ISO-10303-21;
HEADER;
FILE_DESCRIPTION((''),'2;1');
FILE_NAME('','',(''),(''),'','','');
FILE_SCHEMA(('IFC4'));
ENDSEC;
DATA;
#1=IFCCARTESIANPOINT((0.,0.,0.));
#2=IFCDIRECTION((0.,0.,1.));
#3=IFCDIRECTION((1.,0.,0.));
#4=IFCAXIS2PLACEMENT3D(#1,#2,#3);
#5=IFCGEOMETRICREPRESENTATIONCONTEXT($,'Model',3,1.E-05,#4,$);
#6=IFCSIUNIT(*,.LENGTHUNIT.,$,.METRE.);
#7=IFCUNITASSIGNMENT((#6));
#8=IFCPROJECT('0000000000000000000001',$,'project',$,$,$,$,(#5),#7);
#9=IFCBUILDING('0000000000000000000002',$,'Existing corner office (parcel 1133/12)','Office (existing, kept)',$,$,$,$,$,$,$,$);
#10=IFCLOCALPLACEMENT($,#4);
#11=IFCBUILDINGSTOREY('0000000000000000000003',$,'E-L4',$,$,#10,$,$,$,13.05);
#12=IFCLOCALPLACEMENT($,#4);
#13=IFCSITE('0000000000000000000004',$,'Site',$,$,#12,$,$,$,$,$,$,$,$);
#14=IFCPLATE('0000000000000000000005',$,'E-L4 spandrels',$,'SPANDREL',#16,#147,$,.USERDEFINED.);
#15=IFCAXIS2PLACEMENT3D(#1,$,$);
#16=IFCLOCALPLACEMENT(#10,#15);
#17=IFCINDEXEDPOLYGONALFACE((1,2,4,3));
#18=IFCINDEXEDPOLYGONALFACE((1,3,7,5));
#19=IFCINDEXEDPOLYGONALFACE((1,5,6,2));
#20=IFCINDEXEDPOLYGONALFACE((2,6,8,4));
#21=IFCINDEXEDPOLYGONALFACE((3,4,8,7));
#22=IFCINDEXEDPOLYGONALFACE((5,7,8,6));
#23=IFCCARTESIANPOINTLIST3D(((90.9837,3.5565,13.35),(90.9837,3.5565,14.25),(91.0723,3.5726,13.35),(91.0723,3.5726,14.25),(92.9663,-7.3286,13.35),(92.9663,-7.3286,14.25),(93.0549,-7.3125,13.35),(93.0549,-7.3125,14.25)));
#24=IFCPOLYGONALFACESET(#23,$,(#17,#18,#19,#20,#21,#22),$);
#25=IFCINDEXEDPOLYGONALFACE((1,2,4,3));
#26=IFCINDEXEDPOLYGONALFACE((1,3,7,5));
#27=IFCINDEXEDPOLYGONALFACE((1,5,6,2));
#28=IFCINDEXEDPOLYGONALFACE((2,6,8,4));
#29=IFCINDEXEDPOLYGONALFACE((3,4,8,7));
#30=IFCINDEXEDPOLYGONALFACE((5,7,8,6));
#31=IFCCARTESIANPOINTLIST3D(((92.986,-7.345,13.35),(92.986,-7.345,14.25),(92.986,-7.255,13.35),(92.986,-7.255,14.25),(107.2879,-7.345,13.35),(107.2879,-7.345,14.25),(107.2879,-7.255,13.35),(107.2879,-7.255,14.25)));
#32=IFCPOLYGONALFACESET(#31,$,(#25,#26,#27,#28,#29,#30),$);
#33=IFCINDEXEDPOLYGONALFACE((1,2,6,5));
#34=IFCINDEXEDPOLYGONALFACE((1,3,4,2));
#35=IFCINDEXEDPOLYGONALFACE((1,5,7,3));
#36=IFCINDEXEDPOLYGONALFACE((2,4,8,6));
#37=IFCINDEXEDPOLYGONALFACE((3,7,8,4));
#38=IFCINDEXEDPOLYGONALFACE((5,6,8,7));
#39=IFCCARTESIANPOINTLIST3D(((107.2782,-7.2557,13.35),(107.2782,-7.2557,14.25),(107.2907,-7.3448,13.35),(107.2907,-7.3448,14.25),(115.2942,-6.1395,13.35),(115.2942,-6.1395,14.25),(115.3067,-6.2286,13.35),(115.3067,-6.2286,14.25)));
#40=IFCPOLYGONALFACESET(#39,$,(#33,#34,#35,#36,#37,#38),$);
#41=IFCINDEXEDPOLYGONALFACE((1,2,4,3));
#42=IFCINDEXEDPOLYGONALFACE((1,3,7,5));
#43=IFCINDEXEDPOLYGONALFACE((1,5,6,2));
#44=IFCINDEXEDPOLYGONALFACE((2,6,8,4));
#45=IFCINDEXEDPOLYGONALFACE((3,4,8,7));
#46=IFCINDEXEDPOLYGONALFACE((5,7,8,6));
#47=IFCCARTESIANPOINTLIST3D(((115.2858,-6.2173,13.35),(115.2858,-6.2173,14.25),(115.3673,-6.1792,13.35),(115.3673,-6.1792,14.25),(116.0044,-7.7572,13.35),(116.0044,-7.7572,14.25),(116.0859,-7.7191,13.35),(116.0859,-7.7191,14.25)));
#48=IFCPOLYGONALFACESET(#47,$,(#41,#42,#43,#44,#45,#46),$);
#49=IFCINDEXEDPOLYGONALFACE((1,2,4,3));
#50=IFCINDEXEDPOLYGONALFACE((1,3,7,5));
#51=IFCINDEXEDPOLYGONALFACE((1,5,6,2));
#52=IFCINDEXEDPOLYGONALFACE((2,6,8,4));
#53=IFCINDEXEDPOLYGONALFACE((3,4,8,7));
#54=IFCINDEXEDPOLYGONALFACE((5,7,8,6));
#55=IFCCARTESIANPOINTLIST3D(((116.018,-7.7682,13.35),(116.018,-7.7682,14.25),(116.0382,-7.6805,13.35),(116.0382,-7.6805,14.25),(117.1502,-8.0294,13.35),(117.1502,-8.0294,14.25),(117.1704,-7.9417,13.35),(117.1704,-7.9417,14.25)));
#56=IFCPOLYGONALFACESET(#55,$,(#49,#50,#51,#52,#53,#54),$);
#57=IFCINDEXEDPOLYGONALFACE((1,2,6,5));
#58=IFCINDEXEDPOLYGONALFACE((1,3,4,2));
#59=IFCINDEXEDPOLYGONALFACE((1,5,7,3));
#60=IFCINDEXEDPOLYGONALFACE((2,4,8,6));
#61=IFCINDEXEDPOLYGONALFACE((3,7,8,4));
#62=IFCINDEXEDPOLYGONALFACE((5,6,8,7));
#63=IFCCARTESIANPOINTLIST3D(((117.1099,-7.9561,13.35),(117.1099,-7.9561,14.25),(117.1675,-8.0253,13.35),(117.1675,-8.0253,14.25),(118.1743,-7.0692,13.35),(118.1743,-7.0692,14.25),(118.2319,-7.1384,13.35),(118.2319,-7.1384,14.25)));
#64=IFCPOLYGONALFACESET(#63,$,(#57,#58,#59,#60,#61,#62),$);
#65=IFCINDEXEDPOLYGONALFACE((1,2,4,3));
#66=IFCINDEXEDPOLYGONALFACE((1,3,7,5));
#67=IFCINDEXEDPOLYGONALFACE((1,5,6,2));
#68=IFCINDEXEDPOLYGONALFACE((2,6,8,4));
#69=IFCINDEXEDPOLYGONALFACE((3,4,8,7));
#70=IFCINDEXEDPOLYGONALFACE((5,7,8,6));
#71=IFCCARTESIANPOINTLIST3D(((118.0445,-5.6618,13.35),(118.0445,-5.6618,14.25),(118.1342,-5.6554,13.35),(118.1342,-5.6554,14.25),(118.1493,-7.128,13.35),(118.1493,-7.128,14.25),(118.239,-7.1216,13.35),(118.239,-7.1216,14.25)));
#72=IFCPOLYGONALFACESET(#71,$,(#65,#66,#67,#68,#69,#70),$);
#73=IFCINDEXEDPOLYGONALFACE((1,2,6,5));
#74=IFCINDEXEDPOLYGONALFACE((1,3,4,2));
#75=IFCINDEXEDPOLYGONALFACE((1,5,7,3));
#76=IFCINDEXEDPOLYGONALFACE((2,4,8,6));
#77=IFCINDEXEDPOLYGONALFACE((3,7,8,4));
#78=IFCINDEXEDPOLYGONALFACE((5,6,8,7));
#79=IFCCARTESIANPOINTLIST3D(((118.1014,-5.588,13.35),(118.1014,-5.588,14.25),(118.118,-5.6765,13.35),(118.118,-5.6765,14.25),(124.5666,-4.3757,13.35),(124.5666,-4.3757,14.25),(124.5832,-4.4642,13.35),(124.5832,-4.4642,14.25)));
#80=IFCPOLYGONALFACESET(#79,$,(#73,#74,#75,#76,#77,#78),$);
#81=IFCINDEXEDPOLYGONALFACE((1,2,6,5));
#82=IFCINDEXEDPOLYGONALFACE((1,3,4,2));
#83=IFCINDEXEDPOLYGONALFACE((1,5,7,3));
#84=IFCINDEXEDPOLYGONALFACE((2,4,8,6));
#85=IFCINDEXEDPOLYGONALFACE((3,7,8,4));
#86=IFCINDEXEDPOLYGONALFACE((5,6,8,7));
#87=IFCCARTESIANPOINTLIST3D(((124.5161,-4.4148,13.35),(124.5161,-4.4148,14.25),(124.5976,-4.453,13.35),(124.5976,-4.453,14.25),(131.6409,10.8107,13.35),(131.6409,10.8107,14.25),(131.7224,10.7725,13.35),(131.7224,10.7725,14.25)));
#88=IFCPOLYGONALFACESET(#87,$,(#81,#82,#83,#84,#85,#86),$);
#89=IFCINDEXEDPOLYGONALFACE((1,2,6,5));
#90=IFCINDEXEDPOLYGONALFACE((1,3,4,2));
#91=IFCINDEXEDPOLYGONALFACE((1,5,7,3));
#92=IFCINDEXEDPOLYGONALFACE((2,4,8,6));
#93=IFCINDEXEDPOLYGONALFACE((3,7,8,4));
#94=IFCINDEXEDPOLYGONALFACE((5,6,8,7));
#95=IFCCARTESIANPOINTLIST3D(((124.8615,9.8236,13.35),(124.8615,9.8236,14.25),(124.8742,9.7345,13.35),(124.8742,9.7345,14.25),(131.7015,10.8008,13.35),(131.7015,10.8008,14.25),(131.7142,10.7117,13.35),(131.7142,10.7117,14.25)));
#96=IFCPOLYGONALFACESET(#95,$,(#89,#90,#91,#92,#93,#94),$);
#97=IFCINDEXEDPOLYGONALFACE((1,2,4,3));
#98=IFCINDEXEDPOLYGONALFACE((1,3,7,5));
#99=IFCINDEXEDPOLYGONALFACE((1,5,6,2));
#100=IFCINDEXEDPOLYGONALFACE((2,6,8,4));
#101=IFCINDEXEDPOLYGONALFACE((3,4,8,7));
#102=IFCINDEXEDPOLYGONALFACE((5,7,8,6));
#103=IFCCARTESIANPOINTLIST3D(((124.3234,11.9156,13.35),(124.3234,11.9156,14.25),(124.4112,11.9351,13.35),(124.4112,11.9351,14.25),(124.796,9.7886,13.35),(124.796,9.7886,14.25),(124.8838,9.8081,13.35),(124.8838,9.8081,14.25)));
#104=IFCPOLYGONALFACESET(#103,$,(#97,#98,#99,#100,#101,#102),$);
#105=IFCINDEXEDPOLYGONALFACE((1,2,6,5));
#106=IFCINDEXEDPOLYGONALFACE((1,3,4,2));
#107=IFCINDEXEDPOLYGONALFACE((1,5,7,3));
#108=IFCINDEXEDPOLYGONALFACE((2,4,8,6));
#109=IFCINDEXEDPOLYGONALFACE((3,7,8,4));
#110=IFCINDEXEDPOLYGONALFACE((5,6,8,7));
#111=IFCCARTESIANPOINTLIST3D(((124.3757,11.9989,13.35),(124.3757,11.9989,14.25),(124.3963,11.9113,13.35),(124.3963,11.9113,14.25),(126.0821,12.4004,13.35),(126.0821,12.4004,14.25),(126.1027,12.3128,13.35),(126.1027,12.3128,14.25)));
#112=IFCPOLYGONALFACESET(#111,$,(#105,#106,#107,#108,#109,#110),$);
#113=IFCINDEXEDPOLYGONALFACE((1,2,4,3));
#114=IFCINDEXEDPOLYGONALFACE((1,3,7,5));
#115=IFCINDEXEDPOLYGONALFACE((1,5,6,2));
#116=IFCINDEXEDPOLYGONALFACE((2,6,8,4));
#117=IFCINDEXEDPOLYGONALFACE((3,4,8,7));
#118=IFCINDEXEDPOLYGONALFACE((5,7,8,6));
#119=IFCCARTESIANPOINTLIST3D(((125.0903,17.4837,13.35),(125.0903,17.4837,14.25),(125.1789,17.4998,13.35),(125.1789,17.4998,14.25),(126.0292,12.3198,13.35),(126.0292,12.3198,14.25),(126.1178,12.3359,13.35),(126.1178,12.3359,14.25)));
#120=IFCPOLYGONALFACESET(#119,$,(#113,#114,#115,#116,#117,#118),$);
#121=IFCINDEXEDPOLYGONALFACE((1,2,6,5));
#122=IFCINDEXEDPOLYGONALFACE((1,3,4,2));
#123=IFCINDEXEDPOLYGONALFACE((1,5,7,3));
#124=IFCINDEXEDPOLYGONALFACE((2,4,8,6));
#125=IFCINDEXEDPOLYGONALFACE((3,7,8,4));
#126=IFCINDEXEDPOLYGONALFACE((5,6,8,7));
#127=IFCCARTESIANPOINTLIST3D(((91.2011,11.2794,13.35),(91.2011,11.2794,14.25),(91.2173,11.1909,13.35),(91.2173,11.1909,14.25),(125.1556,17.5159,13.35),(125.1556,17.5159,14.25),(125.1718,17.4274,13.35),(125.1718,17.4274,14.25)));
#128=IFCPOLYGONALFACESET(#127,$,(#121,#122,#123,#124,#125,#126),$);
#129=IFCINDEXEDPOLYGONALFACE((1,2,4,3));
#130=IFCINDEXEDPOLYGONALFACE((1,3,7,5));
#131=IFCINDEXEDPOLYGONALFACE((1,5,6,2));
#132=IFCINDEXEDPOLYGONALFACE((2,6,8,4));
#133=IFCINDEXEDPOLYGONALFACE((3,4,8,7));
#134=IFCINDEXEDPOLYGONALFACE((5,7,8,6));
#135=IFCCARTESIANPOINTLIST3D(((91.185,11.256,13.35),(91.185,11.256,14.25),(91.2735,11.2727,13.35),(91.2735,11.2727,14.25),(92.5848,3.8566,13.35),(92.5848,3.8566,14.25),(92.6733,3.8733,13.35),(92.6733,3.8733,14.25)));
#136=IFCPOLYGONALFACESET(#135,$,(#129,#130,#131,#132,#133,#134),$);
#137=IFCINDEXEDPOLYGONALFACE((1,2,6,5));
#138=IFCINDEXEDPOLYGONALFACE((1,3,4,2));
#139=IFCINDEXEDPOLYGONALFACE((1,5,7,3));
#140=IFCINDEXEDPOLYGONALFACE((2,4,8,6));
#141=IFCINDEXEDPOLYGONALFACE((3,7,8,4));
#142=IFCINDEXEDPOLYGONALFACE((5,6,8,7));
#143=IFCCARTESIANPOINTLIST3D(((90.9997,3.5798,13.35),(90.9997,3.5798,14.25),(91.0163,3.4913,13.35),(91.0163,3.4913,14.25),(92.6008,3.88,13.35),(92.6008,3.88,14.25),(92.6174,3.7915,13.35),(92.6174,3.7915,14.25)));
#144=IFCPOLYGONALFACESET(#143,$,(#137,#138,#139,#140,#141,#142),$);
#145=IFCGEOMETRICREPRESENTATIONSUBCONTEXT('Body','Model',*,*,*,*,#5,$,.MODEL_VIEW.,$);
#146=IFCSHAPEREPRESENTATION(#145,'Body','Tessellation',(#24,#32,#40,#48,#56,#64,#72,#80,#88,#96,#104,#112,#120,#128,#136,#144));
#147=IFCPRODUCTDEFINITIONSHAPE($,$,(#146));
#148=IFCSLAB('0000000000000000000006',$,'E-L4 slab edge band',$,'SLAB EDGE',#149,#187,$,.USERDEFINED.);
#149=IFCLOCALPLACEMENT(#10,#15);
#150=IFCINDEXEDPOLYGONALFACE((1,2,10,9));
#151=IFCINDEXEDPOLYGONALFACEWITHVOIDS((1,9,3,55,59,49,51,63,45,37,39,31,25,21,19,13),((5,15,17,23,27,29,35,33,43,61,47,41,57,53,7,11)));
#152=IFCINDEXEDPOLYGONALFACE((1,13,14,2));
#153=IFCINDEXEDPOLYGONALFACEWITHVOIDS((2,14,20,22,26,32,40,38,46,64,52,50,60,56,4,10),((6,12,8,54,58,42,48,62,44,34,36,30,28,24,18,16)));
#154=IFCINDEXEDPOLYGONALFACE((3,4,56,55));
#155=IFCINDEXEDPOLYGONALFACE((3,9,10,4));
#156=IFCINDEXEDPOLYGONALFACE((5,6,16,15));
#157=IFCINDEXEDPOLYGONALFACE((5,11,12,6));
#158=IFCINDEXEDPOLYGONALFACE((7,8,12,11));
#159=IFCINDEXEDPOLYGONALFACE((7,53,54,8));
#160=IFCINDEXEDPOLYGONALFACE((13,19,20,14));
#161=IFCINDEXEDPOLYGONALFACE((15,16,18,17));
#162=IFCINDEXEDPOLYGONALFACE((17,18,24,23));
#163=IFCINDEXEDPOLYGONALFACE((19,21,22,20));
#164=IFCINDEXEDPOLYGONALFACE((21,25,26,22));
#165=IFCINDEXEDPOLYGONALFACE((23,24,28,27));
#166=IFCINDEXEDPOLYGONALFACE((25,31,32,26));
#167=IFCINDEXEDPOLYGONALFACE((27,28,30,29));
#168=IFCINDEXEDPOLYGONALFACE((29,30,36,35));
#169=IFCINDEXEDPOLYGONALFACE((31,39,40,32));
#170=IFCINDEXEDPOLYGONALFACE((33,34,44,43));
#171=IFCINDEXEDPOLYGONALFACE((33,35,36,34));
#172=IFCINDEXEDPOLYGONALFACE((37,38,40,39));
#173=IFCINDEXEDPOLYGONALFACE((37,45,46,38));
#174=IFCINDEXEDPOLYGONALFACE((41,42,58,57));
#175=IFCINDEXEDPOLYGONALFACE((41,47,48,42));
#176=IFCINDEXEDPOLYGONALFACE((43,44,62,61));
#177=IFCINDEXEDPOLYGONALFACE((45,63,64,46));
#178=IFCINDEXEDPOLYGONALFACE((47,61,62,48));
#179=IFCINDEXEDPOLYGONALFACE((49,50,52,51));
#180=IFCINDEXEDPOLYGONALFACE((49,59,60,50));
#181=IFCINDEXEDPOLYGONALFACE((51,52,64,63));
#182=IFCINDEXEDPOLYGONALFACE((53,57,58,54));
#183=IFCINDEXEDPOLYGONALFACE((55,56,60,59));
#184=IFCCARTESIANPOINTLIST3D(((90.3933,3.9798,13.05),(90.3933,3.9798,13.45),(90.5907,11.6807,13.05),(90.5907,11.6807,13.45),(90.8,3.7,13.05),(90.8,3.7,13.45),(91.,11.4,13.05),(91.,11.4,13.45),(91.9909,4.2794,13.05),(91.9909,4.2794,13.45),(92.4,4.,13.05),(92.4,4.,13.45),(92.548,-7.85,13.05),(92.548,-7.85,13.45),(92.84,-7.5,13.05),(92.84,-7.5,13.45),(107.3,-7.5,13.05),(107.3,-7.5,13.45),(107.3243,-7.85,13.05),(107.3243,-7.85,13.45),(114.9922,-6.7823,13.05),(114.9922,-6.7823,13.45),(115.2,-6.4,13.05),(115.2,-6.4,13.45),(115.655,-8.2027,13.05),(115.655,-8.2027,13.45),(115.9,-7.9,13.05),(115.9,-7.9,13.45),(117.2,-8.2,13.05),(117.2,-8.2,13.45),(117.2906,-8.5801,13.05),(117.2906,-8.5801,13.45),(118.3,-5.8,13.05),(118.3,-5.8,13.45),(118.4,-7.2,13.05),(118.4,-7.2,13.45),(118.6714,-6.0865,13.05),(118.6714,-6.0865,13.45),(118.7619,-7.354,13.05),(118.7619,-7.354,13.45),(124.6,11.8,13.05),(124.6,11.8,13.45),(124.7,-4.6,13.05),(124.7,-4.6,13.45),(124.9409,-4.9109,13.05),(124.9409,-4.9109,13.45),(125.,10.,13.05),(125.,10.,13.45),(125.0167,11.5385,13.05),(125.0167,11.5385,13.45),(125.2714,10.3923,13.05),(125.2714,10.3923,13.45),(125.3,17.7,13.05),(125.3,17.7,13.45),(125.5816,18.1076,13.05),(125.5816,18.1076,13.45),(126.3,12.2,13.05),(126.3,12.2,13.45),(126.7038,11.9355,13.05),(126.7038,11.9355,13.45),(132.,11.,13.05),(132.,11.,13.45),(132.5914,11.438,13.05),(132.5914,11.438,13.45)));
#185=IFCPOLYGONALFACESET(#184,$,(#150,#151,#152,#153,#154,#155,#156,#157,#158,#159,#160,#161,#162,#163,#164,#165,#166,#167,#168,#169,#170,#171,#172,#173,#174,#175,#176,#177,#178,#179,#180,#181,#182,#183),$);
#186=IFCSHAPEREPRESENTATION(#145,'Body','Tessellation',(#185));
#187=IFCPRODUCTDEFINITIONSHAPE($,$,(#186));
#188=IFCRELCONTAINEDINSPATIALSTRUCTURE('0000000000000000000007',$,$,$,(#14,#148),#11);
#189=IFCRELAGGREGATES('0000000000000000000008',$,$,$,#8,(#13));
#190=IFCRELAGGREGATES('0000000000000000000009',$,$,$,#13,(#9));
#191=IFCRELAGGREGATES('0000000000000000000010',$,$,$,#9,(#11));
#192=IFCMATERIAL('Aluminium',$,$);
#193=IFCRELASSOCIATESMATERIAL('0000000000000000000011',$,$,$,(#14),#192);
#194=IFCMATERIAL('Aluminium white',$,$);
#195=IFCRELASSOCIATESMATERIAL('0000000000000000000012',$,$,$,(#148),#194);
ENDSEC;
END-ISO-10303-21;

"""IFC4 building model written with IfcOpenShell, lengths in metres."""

from ifc_helpers import new_model, si_unit, frame, origin_with_axes, place, context, subcontext, project, spatial, polyline, outline, extrude, material, element, save


model = new_model("IFC4")

# Units and contexts
model_context = context("Model", 3, precision=1e-05, world=origin_with_axes())
body_context = subcontext(model_context, "Body", "Model", "MODEL_VIEW")
ifc_project = project(units=[si_unit("LENGTHUNIT", "METRE")], contexts=[model_context])

# Site, building, storey
site_placement = place(None, origin_with_axes())
site = spatial("IfcSite", under=ifc_project, at=site_placement, Name="Site")
building = spatial("IfcBuilding", under=site, Name="Existing corner office (parcel 1133/12)", Description="Office (existing, kept)")
storey_placement = place(None, origin_with_axes())
storey = spatial("IfcBuildingStorey", under=building, at=storey_placement, Name="E-L4", Elevation=13.05)

# Shared definitions
ifc_material_1 = material(Name="Aluminium")
ifc_material_2 = material(Name="Aluminium white")

# Plate
plate_placement = place(storey_placement, origin_with_axes())
element("IfcPlate", 1, at=plate_placement, inside=storey, material=ifc_material_1, Name="E-L4 spandrels", ObjectType="SPANDREL", PredefinedType="USERDEFINED", context=body_context, shape_type="SweptSolid", body=[
    extrude(outline(polyline([(90.9837, 3.5565), (92.9663, -7.3286), (93.0549, -7.3125), (91.0723, 3.5726), (90.9837, 3.5565)])), frame((0.0, 0.0, 13.35), z_axis=(0.0, 0.0, 1.0), x_axis=(1.0, 0.0, 0.0)), (0.0, 0.0, 1.0), 0.9),
    extrude(outline(polyline([(92.986, -7.345), (107.2879, -7.345), (107.2879, -7.255), (92.986, -7.255), (92.986, -7.345)])), frame((0.0, 0.0, 13.35), z_axis=(0.0, 0.0, 1.0), x_axis=(1.0, 0.0, 0.0)), (0.0, 0.0, 1.0), 0.9),
    extrude(outline(polyline([(107.2907, -7.3448), (115.3067, -6.2286), (115.2942, -6.1395), (107.2782, -7.2557), (107.2907, -7.3448)])), frame((0.0, 0.0, 13.35), z_axis=(0.0, 0.0, 1.0), x_axis=(1.0, 0.0, 0.0)), (0.0, 0.0, 1.0), 0.9),
    extrude(outline(polyline([(115.2858, -6.2173), (116.0044, -7.7572), (116.0859, -7.7191), (115.3673, -6.1792), (115.2858, -6.2173)])), frame((0.0, 0.0, 13.35), z_axis=(0.0, 0.0, 1.0), x_axis=(1.0, 0.0, 0.0)), (0.0, 0.0, 1.0), 0.9),
    extrude(outline(polyline([(116.018, -7.7682), (117.1502, -8.0294), (117.1704, -7.9417), (116.0382, -7.6805), (116.018, -7.7682)])), frame((0.0, 0.0, 13.35), z_axis=(0.0, 0.0, 1.0), x_axis=(1.0, 0.0, 0.0)), (0.0, 0.0, 1.0), 0.9),
    extrude(outline(polyline([(117.1675, -8.0253), (118.2319, -7.1384), (118.1743, -7.0692), (117.1099, -7.9561), (117.1675, -8.0253)])), frame((0.0, 0.0, 13.35), z_axis=(0.0, 0.0, 1.0), x_axis=(1.0, 0.0, 0.0)), (0.0, 0.0, 1.0), 0.9),
    extrude(outline(polyline([(118.239, -7.1216), (118.1342, -5.6554), (118.0445, -5.6618), (118.1493, -7.128), (118.239, -7.1216)])), frame((0.0, 0.0, 13.35), z_axis=(0.0, 0.0, 1.0), x_axis=(1.0, 0.0, 0.0)), (0.0, 0.0, 1.0), 0.9),
    extrude(outline(polyline([(118.118, -5.6765), (124.5832, -4.4642), (124.5666, -4.3757), (118.1014, -5.588), (118.118, -5.6765)])), frame((0.0, 0.0, 13.35), z_axis=(0.0, 0.0, 1.0), x_axis=(1.0, 0.0, 0.0)), (0.0, 0.0, 1.0), 0.9),
    extrude(outline(polyline([(124.5976, -4.453), (131.7224, 10.7725), (131.6409, 10.8107), (124.5161, -4.4148), (124.5976, -4.453)])), frame((0.0, 0.0, 13.35), z_axis=(0.0, 0.0, 1.0), x_axis=(1.0, 0.0, 0.0)), (0.0, 0.0, 1.0), 0.9),
    extrude(outline(polyline([(131.7015, 10.8008), (124.8615, 9.8236), (124.8742, 9.7345), (131.7142, 10.7117), (131.7015, 10.8008)])), frame((0.0, 0.0, 13.35), z_axis=(0.0, 0.0, 1.0), x_axis=(1.0, 0.0, 0.0)), (0.0, 0.0, 1.0), 0.9),
    extrude(outline(polyline([(124.8838, 9.8081), (124.4112, 11.9351), (124.3234, 11.9156), (124.796, 9.7886), (124.8838, 9.8081)])), frame((0.0, 0.0, 13.35), z_axis=(0.0, 0.0, 1.0), x_axis=(1.0, 0.0, 0.0)), (0.0, 0.0, 1.0), 0.9),
    extrude(outline(polyline([(124.3963, 11.9113), (126.1027, 12.3128), (126.0821, 12.4004), (124.3757, 11.9989), (124.3963, 11.9113)])), frame((0.0, 0.0, 13.35), z_axis=(0.0, 0.0, 1.0), x_axis=(1.0, 0.0, 0.0)), (0.0, 0.0, 1.0), 0.9),
    extrude(outline(polyline([(126.1178, 12.3359), (125.1789, 17.4998), (125.0903, 17.4837), (126.0292, 12.3198), (126.1178, 12.3359)])), frame((0.0, 0.0, 13.35), z_axis=(0.0, 0.0, 1.0), x_axis=(1.0, 0.0, 0.0)), (0.0, 0.0, 1.0), 0.9),
    extrude(outline(polyline([(125.1556, 17.5159), (91.2011, 11.2794), (91.2173, 11.1909), (125.1718, 17.4274), (125.1556, 17.5159)])), frame((0.0, 0.0, 13.35), z_axis=(0.0, 0.0, 1.0), x_axis=(1.0, 0.0, 0.0)), (0.0, 0.0, 1.0), 0.9),
    extrude(outline(polyline([(91.185, 11.256), (92.5848, 3.8566), (92.6733, 3.8733), (91.2735, 11.2727), (91.185, 11.256)])), frame((0.0, 0.0, 13.35), z_axis=(0.0, 0.0, 1.0), x_axis=(1.0, 0.0, 0.0)), (0.0, 0.0, 1.0), 0.9),
    extrude(outline(polyline([(92.6008, 3.88), (90.9997, 3.5798), (91.0163, 3.4913), (92.6174, 3.7915), (92.6008, 3.88)])), frame((0.0, 0.0, 13.35), z_axis=(0.0, 0.0, 1.0), x_axis=(1.0, 0.0, 0.0)), (0.0, 0.0, 1.0), 0.9),
])

# Slab
slab_1_placement = place(storey_placement, origin_with_axes())
element("IfcSlab", 2, at=slab_1_placement, inside=storey, material=ifc_material_2, Name="E-L4 slab edge band", ObjectType="SLAB EDGE", PredefinedType="USERDEFINED", context=body_context, shape_type="SweptSolid", body=[
    extrude(outline(polyline([(90.3933, 3.9798), (92.548, -7.85), (107.3243, -7.85), (114.9922, -6.7823), (115.655, -8.2027), (117.2906, -8.5801), (118.7619, -7.354), (118.6714, -6.0865), (124.9409, -4.9109), (132.5914, 11.438), (125.2714, 10.3923), (125.0167, 11.5385), (126.7038, 11.9355), (125.5816, 18.1076), (90.5907, 11.6807), (91.9909, 4.2794), (90.3933, 3.9798)]), holes=[polyline([(90.8, 3.7), (92.84, -7.5), (107.3, -7.5), (115.2, -6.4), (115.9, -7.9), (117.2, -8.2), (118.4, -7.2), (118.3, -5.8), (124.7, -4.6), (132.0, 11.0), (125.0, 10.0), (124.6, 11.8), (126.3, 12.2), (125.3, 17.7), (91.0, 11.4), (92.4, 4.0), (90.8, 3.7)])]), frame((0.0, 0.0, 13.05), z_axis=(0.0, 0.0, 1.0), x_axis=(1.0, 0.0, 0.0)), (0.0, 0.0, 1.0), 0.4),
])

save(model, "model.ifc")
